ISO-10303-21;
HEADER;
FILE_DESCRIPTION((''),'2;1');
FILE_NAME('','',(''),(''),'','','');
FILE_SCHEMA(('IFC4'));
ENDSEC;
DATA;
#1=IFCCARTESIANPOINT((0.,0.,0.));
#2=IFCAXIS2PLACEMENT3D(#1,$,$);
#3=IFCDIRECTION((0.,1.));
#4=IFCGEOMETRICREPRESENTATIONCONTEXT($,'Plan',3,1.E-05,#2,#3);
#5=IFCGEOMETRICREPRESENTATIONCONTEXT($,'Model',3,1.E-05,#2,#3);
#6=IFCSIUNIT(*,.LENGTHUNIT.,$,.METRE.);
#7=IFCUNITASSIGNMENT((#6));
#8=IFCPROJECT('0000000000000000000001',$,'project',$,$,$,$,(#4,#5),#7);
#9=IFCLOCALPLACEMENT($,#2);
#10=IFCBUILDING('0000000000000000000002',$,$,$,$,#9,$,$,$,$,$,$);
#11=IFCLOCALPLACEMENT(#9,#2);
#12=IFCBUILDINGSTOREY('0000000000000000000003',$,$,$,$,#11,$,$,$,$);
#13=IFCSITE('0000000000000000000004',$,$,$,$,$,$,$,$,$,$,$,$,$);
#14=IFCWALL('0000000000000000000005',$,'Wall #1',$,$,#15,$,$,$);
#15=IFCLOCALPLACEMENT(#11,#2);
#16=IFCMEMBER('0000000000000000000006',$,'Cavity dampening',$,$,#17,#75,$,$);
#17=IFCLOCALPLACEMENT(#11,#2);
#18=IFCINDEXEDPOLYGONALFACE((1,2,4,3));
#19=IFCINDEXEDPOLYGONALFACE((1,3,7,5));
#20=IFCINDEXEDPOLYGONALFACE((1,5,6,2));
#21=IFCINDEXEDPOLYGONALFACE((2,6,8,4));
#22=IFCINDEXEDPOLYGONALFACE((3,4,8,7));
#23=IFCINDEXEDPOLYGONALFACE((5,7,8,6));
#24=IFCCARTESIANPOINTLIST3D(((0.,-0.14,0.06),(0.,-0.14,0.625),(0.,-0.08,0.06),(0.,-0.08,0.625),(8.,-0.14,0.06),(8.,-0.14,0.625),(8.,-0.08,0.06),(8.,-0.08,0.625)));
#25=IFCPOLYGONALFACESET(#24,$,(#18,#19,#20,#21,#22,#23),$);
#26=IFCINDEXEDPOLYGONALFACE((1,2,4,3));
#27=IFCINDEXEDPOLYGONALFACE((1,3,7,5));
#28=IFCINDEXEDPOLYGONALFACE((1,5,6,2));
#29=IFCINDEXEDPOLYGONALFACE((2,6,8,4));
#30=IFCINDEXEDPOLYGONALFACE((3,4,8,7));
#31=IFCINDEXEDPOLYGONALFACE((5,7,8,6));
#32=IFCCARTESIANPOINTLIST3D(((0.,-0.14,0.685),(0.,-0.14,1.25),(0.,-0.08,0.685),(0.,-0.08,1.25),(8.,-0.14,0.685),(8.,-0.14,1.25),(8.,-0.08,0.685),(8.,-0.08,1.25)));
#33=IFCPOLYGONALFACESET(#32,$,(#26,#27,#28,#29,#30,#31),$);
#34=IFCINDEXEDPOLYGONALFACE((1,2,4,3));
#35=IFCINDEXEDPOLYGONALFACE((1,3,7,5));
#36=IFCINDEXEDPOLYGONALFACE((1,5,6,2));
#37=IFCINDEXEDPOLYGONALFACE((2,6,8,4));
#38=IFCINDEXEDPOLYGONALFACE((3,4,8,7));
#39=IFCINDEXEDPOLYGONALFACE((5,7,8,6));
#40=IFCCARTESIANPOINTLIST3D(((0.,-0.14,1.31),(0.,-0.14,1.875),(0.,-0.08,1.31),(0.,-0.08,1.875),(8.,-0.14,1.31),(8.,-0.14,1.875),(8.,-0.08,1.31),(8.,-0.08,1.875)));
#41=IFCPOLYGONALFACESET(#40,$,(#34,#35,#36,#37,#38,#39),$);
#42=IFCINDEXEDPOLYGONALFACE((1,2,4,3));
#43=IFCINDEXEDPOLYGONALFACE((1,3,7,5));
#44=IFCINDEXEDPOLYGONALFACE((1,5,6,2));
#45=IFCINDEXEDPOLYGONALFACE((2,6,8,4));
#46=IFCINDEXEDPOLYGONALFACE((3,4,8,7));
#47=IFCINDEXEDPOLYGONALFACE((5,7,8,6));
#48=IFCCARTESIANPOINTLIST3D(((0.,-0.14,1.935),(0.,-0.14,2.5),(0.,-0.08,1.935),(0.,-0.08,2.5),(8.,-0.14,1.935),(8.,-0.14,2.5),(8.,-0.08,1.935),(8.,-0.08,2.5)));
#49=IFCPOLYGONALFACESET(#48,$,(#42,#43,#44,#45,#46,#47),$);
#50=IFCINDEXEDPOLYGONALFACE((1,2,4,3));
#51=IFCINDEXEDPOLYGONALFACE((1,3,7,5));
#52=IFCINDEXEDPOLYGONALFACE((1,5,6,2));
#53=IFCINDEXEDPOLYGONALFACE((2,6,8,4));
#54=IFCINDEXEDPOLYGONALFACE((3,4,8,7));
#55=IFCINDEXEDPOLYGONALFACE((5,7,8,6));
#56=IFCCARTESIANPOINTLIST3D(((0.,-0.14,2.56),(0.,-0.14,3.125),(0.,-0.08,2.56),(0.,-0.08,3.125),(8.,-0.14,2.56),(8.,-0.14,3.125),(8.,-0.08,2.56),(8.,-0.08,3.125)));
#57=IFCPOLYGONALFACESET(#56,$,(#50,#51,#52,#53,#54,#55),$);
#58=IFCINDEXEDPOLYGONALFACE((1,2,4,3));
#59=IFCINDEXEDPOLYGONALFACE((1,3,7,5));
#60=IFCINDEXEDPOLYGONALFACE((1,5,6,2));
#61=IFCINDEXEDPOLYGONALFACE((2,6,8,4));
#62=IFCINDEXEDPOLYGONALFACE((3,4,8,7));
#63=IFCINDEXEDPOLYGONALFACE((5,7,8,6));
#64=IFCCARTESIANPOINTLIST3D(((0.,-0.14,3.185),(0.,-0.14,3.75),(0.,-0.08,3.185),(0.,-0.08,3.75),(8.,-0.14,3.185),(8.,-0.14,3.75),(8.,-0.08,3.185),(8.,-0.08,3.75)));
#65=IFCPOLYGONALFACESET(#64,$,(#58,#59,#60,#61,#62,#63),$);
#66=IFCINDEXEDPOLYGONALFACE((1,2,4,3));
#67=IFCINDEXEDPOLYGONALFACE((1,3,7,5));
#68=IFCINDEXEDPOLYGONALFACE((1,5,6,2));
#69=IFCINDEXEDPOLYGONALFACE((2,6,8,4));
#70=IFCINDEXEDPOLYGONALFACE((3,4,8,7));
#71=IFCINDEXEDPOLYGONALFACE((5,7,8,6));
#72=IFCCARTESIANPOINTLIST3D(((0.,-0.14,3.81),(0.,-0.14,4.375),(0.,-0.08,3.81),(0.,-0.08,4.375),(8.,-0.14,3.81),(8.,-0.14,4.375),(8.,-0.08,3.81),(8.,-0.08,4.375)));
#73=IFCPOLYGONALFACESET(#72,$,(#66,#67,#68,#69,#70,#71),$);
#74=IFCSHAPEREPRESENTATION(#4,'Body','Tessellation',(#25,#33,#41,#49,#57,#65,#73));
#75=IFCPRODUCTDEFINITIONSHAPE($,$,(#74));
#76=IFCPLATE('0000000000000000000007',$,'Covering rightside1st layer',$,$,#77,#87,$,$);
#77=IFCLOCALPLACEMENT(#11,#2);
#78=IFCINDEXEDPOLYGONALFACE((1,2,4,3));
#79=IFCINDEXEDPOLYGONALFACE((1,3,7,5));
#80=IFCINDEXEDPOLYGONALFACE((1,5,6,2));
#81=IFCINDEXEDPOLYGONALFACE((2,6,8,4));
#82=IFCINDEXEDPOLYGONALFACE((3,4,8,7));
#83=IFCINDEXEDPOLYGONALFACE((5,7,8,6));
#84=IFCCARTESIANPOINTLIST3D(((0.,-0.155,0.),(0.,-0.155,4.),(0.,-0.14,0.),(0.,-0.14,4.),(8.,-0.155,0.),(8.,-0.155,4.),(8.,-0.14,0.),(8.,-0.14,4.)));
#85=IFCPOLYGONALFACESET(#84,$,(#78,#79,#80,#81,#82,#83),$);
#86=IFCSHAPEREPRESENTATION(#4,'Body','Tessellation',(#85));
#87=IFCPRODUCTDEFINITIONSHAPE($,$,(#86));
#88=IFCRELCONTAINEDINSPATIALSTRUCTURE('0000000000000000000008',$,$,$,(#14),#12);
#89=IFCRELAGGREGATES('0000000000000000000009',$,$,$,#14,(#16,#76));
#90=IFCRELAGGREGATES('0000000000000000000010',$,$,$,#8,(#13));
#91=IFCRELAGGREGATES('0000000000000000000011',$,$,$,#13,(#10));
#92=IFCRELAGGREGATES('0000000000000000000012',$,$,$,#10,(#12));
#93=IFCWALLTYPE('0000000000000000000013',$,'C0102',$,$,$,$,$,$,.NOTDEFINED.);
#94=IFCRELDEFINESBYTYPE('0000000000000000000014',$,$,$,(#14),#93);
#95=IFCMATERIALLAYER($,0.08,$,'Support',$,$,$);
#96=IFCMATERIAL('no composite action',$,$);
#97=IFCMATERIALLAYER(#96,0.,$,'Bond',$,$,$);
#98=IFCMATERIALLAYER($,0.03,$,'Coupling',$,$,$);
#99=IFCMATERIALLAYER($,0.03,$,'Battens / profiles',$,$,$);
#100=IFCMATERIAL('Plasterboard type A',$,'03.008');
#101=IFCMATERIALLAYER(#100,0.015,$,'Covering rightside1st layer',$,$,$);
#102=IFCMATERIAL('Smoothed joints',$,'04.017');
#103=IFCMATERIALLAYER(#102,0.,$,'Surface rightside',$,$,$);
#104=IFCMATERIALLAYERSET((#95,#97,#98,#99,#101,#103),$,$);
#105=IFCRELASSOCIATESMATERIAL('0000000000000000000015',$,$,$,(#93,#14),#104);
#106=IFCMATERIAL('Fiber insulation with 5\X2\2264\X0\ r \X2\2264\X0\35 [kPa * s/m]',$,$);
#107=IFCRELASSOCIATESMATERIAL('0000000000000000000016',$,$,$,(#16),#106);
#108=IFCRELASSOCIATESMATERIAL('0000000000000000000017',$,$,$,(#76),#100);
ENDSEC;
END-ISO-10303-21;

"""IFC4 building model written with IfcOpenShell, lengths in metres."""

from ifc_helpers import new_model, si_unit, direction, frame, frame_2d, origin, place, context, project, spatial, rectangle, extrude, material, layer, layer_set, type_object, element, aggregate, save


model = new_model("IFC4")

# Units and contexts
plan_context = context("Plan", 3, precision=1e-05, world=origin(), true_north=direction((0.0, 1.0)))
model_context = context("Model", 3, precision=1e-05, world=origin(), true_north=direction((0.0, 1.0)))
ifc_project = project(units=[si_unit("LENGTHUNIT", "METRE")], contexts=[plan_context, model_context])

# Site, building, storey
site = spatial("IfcSite", under=ifc_project)
building_placement = place(None, origin())
building = spatial("IfcBuilding", under=site, at=building_placement)
storey_placement = place(building_placement, origin())
storey = spatial("IfcBuildingStorey", under=building, at=storey_placement)

# Wall, member, plate
ifc_layer_1 = layer(None, 0.08, Name="Support")
ifc_material_1 = material(Name="no composite action")
ifc_layer_2 = layer(ifc_material_1, 0.0, Name="Bond")
ifc_layer_3 = layer(None, 0.03, Name="Coupling")
ifc_layer_4 = layer(None, 0.03, Name="Battens / profiles")
ifc_material_2 = material(Name="Plasterboard type A", Category="03.008")
ifc_layer_5 = layer(ifc_material_2, 0.015, Name="Covering rightside1st layer")
ifc_material_3 = material(Name="Smoothed joints", Category="04.017")
ifc_layer_6 = layer(ifc_material_3, 0.0, Name="Surface rightside")
ifc_layer_set = layer_set([ifc_layer_1, ifc_layer_2, ifc_layer_3, ifc_layer_4, ifc_layer_5, ifc_layer_6])
wall_type = type_object("IfcWallType", Name="C0102", PredefinedType="NOTDEFINED", material=ifc_layer_set)
wall_placement = place(None, frame((0.0, 0.0, 0.0), z_axis=(0.0, -1.0, 0.0), x_axis=(1.0, 0.0, 0.0)))
wall = element("IfcWall", 1, at=wall_placement, inside=storey, type_object=wall_type, material=ifc_layer_set, Name="Wall #1")
ifc_material_4 = material(Name="Fiber insulation with 5≤ r ≤35 [kPa * s/m]")
member_1_placement = place(wall_placement, origin())
member_1 = element("IfcMember", 2, at=member_1_placement, material=ifc_material_4, Name="Cavity dampening", context=plan_context, shape_type="SweptSolid", body=[
    extrude(rectangle(XDim=0.565, YDim=0.06, at=frame_2d((0.2825, 0.03), x_axis=(1.0, 0.0))), frame((0.0, 0.06, 0.08), z_axis=(1.0, 0.0, 0.0), x_axis=(0.0, 1.0, 0.0)), (0.0, 0.0, 1.0), 8.0),
    extrude(rectangle(XDim=0.565, YDim=0.06, at=frame_2d((0.2825, 0.03), x_axis=(1.0, 0.0))), frame((0.0, 0.685, 0.08), z_axis=(1.0, 0.0, 0.0), x_axis=(0.0, 1.0, 0.0)), (0.0, 0.0, 1.0), 8.0),
    extrude(rectangle(XDim=0.565, YDim=0.06, at=frame_2d((0.2825, 0.03), x_axis=(1.0, 0.0))), frame((0.0, 1.31, 0.08), z_axis=(1.0, 0.0, 0.0), x_axis=(0.0, 1.0, 0.0)), (0.0, 0.0, 1.0), 8.0),
    extrude(rectangle(XDim=0.565, YDim=0.06, at=frame_2d((0.2825, 0.03), x_axis=(1.0, 0.0))), frame((0.0, 1.935, 0.08), z_axis=(1.0, 0.0, 0.0), x_axis=(0.0, 1.0, 0.0)), (0.0, 0.0, 1.0), 8.0),
    extrude(rectangle(XDim=0.565, YDim=0.06, at=frame_2d((0.2825, 0.03), x_axis=(1.0, 0.0))), frame((0.0, 2.56, 0.08), z_axis=(1.0, 0.0, 0.0), x_axis=(0.0, 1.0, 0.0)), (0.0, 0.0, 1.0), 8.0),
    extrude(rectangle(XDim=0.565, YDim=0.06, at=frame_2d((0.2825, 0.03), x_axis=(1.0, 0.0))), frame((0.0, 3.185, 0.08), z_axis=(1.0, 0.0, 0.0), x_axis=(0.0, 1.0, 0.0)), (0.0, 0.0, 1.0), 8.0),
    extrude(rectangle(XDim=0.565, YDim=0.06, at=frame_2d((0.2825, 0.03), x_axis=(1.0, 0.0))), frame((0.0, 3.81, 0.08), z_axis=(1.0, 0.0, 0.0), x_axis=(0.0, 1.0, 0.0)), (0.0, 0.0, 1.0), 8.0),
])
plate_placement = place(wall_placement, origin())
plate = element("IfcPlate", 3, at=plate_placement, material=ifc_material_2, Name="Covering rightside1st layer", context=plan_context, shape_type="SweptSolid", body=[
    extrude(rectangle(XDim=8.0, YDim=4.0, at=frame_2d((4.0, 2.0), x_axis=(1.0, 0.0))), frame((0.0, 0.0, 0.14), z_axis=(0.0, 0.0, 1.0), x_axis=(1.0, 0.0, 0.0)), (0.0, 0.0, 1.0), 0.015),
])
aggregate(wall, [member_1, plate])

save(model, "model.ifc")
